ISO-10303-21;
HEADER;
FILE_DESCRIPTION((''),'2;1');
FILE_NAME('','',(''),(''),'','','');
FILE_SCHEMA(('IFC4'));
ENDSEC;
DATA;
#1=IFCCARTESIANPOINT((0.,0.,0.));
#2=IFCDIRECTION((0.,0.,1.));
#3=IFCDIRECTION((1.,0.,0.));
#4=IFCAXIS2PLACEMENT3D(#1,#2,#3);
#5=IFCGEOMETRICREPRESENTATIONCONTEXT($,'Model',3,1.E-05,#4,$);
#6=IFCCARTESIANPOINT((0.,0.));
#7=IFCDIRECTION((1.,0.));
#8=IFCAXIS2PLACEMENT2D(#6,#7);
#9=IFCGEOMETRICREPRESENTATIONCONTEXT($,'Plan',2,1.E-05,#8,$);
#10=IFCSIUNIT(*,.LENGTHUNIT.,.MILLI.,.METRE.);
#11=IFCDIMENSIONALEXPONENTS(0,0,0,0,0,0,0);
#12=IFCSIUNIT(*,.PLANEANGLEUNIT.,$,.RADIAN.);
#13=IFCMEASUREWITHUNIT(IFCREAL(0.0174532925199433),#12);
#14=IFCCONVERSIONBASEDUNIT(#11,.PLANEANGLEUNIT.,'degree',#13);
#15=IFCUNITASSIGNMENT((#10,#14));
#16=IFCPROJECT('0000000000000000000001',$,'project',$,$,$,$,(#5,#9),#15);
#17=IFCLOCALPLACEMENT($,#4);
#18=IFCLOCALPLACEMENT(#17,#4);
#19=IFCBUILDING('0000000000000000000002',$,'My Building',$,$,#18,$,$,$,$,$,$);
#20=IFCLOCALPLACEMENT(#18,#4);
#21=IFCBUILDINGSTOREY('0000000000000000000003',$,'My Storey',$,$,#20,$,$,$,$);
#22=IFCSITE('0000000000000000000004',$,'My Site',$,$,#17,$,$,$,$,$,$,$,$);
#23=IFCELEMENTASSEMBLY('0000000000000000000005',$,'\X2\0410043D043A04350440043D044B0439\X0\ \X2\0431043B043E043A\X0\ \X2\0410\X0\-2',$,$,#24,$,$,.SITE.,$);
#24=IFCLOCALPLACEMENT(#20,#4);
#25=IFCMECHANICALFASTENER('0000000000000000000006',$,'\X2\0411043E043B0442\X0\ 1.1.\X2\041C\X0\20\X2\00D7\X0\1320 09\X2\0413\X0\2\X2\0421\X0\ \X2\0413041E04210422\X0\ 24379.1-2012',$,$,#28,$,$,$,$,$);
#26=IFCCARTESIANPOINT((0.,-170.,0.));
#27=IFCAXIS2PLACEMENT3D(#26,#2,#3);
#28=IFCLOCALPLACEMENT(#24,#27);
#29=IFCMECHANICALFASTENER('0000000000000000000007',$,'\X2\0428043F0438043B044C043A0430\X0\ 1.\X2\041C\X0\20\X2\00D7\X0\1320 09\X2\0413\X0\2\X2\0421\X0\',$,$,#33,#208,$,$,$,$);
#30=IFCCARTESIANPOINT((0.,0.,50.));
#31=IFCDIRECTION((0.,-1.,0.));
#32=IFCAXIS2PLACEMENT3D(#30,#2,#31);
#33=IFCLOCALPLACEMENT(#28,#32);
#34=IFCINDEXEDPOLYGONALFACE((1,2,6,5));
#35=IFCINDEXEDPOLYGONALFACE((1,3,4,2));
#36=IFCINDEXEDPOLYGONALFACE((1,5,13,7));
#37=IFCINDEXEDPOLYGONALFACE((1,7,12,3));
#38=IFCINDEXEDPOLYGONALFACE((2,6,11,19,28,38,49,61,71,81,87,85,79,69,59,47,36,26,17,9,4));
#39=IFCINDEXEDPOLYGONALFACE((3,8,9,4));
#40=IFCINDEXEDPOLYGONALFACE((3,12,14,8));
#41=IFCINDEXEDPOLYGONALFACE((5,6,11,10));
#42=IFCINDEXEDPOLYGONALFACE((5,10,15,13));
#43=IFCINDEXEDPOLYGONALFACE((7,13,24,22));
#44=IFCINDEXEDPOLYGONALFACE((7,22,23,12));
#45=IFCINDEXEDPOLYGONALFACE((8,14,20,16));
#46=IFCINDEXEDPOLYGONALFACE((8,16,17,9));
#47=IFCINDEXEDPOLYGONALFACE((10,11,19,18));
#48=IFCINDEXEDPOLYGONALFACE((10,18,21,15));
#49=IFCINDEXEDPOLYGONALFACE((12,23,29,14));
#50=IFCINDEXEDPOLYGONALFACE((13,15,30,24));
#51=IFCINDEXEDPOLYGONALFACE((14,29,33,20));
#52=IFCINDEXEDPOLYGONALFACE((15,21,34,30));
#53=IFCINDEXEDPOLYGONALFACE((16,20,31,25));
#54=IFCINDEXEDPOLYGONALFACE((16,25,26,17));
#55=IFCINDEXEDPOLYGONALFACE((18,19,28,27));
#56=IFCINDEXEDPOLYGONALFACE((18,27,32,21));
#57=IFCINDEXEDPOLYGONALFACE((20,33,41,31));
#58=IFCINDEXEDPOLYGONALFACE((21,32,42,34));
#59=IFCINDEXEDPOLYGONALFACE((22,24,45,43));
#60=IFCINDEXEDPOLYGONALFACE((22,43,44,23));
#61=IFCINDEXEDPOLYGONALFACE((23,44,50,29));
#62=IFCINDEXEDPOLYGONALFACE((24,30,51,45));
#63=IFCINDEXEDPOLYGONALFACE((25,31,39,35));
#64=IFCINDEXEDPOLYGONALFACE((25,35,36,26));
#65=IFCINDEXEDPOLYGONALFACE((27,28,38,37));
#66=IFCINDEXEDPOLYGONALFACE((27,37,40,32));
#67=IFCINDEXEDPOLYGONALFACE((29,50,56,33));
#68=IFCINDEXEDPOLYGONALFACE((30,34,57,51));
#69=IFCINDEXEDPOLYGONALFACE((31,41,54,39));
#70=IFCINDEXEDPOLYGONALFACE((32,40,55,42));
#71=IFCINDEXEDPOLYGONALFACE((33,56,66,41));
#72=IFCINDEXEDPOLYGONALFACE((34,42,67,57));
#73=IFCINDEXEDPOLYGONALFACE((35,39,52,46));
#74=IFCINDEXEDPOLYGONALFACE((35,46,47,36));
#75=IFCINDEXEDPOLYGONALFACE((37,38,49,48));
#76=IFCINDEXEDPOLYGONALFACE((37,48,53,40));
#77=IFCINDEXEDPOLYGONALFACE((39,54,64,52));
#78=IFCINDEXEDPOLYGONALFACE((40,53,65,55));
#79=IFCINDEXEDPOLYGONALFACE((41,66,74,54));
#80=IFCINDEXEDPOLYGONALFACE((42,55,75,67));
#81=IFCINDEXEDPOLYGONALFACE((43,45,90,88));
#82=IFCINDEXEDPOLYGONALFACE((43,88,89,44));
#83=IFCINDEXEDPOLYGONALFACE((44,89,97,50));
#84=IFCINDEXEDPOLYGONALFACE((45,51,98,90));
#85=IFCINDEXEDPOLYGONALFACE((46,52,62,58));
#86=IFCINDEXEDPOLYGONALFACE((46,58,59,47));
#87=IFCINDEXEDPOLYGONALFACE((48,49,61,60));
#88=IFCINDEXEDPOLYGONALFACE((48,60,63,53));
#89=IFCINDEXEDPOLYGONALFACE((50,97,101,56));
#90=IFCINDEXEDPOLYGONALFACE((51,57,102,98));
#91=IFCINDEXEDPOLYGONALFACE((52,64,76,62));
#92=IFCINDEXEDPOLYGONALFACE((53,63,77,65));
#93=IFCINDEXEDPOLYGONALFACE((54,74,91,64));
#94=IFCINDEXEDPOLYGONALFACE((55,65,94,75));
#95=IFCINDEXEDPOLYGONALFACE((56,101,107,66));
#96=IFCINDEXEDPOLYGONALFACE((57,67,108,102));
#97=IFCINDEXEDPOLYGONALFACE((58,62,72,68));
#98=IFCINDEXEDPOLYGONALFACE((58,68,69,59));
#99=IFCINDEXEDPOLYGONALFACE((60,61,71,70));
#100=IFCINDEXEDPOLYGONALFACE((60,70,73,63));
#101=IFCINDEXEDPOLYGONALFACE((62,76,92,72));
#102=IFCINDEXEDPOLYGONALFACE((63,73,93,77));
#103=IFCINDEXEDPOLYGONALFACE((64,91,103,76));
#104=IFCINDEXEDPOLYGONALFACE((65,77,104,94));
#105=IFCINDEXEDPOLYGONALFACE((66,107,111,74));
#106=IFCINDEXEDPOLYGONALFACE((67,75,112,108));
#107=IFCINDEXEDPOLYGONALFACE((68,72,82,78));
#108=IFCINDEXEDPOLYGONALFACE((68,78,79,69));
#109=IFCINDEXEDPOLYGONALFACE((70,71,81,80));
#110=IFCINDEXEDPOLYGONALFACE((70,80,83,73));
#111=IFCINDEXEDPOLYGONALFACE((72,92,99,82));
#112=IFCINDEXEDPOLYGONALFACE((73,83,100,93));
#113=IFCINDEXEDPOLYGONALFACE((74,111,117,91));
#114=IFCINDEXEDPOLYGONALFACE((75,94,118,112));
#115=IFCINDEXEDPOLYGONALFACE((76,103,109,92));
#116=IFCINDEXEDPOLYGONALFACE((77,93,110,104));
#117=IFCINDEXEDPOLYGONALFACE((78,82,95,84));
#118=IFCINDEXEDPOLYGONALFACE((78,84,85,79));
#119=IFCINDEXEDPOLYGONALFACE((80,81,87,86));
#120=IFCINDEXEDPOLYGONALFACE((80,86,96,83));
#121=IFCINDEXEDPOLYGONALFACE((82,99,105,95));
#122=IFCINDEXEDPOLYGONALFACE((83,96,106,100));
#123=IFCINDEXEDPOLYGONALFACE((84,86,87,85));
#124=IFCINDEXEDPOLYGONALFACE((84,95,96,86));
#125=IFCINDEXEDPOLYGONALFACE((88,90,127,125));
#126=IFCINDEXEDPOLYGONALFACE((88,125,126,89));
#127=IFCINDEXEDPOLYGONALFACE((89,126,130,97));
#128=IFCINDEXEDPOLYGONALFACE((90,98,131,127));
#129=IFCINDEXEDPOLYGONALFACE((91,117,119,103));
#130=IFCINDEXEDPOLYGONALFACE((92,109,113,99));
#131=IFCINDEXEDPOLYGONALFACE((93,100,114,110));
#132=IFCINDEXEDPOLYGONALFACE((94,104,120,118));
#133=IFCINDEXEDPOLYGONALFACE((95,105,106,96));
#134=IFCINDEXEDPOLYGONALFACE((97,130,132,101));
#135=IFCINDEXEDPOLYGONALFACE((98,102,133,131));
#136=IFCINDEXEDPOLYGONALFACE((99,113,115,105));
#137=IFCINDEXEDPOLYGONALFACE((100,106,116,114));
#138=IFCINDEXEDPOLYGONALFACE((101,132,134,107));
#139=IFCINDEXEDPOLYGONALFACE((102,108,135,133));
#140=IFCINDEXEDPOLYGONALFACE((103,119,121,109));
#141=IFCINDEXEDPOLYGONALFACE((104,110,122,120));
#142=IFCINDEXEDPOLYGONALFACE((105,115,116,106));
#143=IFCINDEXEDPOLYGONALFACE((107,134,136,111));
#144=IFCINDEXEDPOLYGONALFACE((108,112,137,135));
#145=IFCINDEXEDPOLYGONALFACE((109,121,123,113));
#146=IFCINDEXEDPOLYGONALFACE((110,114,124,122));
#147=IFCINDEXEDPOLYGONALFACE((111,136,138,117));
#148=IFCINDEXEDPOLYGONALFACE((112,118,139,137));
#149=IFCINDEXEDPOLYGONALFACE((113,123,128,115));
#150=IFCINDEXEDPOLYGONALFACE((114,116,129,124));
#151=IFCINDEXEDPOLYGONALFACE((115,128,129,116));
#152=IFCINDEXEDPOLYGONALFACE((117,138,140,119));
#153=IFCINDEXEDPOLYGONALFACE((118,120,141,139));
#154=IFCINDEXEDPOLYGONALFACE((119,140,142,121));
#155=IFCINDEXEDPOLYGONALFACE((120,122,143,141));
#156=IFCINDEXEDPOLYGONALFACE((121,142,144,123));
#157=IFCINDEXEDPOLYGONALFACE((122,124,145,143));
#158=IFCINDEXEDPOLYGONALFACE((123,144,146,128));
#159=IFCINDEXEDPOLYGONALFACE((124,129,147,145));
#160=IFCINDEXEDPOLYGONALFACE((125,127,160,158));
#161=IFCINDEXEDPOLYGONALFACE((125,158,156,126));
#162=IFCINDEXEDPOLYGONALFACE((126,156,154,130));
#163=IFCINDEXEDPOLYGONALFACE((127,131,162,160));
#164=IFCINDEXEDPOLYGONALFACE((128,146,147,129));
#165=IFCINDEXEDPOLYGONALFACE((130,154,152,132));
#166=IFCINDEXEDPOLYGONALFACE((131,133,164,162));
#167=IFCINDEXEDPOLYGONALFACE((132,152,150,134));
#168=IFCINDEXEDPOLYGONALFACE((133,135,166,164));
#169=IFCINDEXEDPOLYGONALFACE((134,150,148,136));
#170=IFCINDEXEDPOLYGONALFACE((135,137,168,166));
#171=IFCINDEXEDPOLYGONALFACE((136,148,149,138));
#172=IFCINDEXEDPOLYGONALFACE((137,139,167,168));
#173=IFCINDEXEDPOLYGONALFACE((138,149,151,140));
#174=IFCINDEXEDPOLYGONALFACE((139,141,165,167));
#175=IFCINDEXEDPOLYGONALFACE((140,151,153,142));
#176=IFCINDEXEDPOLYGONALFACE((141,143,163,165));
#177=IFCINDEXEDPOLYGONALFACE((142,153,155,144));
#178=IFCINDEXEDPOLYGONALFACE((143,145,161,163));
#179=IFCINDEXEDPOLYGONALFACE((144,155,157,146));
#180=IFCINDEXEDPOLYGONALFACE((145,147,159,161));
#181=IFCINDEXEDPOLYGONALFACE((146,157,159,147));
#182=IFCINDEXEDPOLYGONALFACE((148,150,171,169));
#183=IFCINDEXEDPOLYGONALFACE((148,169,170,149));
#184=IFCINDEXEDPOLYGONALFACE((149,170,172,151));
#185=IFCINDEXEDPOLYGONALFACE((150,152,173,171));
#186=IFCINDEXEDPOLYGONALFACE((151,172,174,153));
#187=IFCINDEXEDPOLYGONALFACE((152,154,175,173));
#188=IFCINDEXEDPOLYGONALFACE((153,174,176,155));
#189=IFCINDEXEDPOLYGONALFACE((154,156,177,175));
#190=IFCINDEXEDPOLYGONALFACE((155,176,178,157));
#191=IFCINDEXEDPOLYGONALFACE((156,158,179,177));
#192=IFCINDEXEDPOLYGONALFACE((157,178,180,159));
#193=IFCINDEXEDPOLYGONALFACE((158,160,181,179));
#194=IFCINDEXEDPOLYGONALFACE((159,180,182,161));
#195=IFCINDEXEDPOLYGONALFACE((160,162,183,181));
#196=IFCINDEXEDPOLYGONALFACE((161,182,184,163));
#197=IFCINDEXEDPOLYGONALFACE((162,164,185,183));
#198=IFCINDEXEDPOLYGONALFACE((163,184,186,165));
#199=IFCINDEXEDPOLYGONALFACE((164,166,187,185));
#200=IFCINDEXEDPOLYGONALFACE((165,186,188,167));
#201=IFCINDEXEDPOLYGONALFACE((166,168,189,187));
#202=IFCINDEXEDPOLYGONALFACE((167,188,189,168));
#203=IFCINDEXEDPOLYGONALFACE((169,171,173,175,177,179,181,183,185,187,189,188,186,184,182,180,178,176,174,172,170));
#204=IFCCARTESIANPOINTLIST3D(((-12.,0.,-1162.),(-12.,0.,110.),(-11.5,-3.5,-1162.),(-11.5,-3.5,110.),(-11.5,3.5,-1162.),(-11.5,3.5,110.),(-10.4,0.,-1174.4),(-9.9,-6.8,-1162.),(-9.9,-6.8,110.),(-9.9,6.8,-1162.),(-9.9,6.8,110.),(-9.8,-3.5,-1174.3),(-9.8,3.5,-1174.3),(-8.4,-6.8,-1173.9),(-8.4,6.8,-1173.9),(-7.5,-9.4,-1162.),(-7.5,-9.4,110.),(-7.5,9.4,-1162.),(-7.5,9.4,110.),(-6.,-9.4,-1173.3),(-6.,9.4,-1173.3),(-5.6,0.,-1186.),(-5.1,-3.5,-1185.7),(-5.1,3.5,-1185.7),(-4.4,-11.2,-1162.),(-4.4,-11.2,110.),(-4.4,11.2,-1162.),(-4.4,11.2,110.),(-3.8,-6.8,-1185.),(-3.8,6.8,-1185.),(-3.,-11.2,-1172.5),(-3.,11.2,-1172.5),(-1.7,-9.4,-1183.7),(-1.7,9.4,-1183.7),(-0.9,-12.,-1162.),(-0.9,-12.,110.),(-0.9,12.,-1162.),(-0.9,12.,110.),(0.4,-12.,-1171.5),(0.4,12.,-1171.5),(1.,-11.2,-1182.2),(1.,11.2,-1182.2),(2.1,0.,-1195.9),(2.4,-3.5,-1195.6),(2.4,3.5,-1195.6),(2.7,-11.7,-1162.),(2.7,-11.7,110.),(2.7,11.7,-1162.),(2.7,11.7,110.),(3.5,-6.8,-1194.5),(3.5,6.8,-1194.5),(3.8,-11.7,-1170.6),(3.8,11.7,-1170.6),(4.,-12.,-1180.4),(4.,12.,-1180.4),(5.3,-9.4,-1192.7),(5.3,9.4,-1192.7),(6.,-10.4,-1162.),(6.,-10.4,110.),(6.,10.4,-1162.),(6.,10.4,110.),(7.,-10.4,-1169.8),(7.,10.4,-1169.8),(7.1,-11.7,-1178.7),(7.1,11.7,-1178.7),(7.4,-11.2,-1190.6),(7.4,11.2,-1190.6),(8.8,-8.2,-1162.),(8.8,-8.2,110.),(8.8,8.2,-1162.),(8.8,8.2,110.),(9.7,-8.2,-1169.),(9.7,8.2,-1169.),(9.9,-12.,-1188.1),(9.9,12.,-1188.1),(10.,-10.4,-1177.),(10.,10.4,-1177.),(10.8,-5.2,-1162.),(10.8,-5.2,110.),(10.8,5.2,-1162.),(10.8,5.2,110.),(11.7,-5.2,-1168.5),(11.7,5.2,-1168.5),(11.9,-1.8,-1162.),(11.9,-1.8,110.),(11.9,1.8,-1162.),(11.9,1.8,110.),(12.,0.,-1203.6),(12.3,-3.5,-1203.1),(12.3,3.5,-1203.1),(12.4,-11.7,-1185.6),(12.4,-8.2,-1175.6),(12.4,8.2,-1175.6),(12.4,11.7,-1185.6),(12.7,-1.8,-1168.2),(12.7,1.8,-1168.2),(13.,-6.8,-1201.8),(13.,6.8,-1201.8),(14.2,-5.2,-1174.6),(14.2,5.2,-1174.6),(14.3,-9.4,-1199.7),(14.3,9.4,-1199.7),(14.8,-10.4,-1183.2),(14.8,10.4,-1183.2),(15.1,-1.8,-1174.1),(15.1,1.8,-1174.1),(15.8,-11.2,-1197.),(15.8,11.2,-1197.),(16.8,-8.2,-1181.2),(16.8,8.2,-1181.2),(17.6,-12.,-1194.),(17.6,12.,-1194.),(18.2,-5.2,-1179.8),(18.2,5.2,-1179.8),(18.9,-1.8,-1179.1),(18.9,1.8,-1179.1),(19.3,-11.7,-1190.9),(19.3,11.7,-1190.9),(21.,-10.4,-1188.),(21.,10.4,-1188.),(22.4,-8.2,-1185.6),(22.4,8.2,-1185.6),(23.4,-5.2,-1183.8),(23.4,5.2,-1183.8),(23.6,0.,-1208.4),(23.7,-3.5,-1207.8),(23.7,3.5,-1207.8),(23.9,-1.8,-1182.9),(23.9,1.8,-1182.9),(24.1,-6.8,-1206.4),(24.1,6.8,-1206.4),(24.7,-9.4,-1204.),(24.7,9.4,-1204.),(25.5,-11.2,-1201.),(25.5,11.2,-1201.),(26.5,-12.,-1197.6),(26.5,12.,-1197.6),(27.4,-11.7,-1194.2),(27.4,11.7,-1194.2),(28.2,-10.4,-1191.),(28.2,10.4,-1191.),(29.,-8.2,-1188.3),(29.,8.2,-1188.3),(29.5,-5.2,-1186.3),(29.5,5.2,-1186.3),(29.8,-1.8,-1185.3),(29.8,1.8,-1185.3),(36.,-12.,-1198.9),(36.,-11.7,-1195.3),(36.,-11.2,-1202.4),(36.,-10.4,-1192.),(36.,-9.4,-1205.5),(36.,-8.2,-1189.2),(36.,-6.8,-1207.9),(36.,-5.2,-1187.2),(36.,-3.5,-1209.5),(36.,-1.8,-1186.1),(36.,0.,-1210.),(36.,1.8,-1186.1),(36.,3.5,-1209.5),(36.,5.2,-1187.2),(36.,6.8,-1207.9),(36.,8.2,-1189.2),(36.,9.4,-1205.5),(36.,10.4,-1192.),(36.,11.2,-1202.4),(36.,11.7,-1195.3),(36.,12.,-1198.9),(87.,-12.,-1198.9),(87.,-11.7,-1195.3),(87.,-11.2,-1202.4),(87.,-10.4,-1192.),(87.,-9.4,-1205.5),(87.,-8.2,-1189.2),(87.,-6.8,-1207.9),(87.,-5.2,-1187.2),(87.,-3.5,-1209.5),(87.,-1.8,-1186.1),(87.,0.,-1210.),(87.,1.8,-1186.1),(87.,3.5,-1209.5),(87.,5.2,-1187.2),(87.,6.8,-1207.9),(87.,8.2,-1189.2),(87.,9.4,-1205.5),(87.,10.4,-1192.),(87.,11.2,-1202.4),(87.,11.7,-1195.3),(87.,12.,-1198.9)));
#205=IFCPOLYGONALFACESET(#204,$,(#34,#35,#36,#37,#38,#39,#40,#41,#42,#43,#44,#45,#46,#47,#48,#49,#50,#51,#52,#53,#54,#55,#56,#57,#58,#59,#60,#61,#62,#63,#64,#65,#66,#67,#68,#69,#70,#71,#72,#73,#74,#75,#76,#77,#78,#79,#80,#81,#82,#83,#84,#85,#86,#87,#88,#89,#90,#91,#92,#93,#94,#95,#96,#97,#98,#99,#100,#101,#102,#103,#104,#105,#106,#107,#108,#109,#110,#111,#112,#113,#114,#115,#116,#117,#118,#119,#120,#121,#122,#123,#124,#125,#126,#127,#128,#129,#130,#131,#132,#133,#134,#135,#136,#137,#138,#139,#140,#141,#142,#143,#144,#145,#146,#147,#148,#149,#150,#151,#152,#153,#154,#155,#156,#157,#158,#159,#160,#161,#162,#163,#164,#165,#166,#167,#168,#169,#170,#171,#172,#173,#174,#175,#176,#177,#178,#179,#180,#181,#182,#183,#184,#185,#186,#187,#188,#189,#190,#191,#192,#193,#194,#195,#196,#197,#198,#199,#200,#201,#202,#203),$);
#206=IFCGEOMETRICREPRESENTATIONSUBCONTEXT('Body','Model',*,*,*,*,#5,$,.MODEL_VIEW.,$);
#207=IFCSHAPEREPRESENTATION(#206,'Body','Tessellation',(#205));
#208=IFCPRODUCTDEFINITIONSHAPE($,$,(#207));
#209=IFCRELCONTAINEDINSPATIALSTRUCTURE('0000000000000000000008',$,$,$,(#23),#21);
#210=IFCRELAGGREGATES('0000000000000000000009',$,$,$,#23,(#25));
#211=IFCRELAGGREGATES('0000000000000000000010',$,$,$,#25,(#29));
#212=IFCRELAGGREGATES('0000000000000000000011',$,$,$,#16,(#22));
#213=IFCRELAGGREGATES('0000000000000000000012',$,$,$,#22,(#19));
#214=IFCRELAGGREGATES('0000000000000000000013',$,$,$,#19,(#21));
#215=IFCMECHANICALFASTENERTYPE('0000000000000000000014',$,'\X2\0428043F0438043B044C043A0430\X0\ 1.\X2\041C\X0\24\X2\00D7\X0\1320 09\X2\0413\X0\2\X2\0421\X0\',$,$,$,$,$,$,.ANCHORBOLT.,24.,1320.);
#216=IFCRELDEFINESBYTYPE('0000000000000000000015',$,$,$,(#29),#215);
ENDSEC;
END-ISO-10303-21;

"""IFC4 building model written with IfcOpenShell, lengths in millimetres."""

from ifc_helpers import new_model, entity, si_unit, converted_unit, frame, origin_with_axes, origin_2d_with_axis, place, context, subcontext, project, spatial, source, transform, mapped, type_object, type_shapes, element, aggregate, save


model = new_model("IFC4")

# Units and contexts
model_context = context("Model", 3, precision=1e-05, world=origin_with_axes())
plan_context = context("Plan", 2, precision=1e-05, world=origin_2d_with_axis())
body_context = subcontext(model_context, "Body", "Model", "MODEL_VIEW")
ifc_project = project(units=[si_unit("LENGTHUNIT", "METRE", prefix="MILLI"), converted_unit("PLANEANGLEUNIT", "degree", entity("IfcReal", 0.0174532925199433), si_unit("PLANEANGLEUNIT", "RADIAN"), dimensions=[0, 0, 0, 0, 0, 0, 0])], contexts=[model_context, plan_context])

# Site, building, storey
site_placement = place(None, origin_with_axes())
site = spatial("IfcSite", under=ifc_project, at=site_placement, Name="My Site")
building_placement = place(site_placement, origin_with_axes())
building = spatial("IfcBuilding", under=site, at=building_placement, Name="My Building")
storey_placement = place(building_placement, origin_with_axes())
storey = spatial("IfcBuildingStorey", under=building, at=storey_placement, Name="My Storey")

# Element assembly, mechanical fasteners
assembly_placement = place(storey_placement, origin_with_axes())
assembly = element("IfcElementAssembly", 1, at=assembly_placement, inside=storey, Name="Анкерный блок А-2", AssemblyPlace="SITE")
mechanical_fastener_1_placement = place(assembly_placement, frame((0.0, -170.0, 0.0), z_axis=(0.0, 0.0, 1.0), x_axis=(1.0, 0.0, 0.0)))
mechanical_fastener_1 = element("IfcMechanicalFastener", 2, at=mechanical_fastener_1_placement, Name="Болт 1.1.М20×1320 09Г2С ГОСТ 24379.1-2012")
aggregate(assembly, [mechanical_fastener_1])
mechanical_fastener_type = type_object("IfcMechanicalFastenerType", Name="Шпилька 1.М24×1320 09Г2С", NominalDiameter=24.0, NominalLength=1320.0, PredefinedType="ANCHORBOLT")
shared_shape = source(frame((0.0, 0.0, 110.0), z_axis=(0.0, 0.0, 1.0), x_axis=(1.0, 0.0, 0.0)), body_context, "Body", "SolidModel", [
    entity("IfcSweptDiskSolid", entity("IfcIndexedPolyCurve", entity("IfcCartesianPointList3D", [[0.0, 0.0, 0.0], [0.0, 0.0, -1272.0], [10.5, 0.0, -1297.5], [36.0, 0.0, -1308.0], [87.0, 0.0, -1308.0]]), [entity("IfcLineIndex", [1, 2]), entity("IfcArcIndex", [2, 3, 4]), entity("IfcLineIndex", [4, 5])]), 12.0),
])
type_shapes(mechanical_fastener_type, [shared_shape])
mechanical_fastener_2_placement = place(mechanical_fastener_1_placement, frame((0.0, 0.0, 50.0), z_axis=(0.0, 0.0, 1.0), x_axis=(0.0, -1.0, 0.0)))
mechanical_fastener_2 = element("IfcMechanicalFastener", 3, at=mechanical_fastener_2_placement, type_object=mechanical_fastener_type, Name="Шпилька 1.М20×1320 09Г2С", context=body_context, shape_type="MappedRepresentation", body=[
    mapped(shared_shape, transform((0.0, 0.0, 0.0), x_axis=(1.0, 0.0, 0.0), y_axis=(0.0, 1.0, 0.0), z_axis=(0.0, 0.0, 1.0), scale=1.0)),
])
aggregate(mechanical_fastener_1, [mechanical_fastener_2])

save(model, "model.ifc")
